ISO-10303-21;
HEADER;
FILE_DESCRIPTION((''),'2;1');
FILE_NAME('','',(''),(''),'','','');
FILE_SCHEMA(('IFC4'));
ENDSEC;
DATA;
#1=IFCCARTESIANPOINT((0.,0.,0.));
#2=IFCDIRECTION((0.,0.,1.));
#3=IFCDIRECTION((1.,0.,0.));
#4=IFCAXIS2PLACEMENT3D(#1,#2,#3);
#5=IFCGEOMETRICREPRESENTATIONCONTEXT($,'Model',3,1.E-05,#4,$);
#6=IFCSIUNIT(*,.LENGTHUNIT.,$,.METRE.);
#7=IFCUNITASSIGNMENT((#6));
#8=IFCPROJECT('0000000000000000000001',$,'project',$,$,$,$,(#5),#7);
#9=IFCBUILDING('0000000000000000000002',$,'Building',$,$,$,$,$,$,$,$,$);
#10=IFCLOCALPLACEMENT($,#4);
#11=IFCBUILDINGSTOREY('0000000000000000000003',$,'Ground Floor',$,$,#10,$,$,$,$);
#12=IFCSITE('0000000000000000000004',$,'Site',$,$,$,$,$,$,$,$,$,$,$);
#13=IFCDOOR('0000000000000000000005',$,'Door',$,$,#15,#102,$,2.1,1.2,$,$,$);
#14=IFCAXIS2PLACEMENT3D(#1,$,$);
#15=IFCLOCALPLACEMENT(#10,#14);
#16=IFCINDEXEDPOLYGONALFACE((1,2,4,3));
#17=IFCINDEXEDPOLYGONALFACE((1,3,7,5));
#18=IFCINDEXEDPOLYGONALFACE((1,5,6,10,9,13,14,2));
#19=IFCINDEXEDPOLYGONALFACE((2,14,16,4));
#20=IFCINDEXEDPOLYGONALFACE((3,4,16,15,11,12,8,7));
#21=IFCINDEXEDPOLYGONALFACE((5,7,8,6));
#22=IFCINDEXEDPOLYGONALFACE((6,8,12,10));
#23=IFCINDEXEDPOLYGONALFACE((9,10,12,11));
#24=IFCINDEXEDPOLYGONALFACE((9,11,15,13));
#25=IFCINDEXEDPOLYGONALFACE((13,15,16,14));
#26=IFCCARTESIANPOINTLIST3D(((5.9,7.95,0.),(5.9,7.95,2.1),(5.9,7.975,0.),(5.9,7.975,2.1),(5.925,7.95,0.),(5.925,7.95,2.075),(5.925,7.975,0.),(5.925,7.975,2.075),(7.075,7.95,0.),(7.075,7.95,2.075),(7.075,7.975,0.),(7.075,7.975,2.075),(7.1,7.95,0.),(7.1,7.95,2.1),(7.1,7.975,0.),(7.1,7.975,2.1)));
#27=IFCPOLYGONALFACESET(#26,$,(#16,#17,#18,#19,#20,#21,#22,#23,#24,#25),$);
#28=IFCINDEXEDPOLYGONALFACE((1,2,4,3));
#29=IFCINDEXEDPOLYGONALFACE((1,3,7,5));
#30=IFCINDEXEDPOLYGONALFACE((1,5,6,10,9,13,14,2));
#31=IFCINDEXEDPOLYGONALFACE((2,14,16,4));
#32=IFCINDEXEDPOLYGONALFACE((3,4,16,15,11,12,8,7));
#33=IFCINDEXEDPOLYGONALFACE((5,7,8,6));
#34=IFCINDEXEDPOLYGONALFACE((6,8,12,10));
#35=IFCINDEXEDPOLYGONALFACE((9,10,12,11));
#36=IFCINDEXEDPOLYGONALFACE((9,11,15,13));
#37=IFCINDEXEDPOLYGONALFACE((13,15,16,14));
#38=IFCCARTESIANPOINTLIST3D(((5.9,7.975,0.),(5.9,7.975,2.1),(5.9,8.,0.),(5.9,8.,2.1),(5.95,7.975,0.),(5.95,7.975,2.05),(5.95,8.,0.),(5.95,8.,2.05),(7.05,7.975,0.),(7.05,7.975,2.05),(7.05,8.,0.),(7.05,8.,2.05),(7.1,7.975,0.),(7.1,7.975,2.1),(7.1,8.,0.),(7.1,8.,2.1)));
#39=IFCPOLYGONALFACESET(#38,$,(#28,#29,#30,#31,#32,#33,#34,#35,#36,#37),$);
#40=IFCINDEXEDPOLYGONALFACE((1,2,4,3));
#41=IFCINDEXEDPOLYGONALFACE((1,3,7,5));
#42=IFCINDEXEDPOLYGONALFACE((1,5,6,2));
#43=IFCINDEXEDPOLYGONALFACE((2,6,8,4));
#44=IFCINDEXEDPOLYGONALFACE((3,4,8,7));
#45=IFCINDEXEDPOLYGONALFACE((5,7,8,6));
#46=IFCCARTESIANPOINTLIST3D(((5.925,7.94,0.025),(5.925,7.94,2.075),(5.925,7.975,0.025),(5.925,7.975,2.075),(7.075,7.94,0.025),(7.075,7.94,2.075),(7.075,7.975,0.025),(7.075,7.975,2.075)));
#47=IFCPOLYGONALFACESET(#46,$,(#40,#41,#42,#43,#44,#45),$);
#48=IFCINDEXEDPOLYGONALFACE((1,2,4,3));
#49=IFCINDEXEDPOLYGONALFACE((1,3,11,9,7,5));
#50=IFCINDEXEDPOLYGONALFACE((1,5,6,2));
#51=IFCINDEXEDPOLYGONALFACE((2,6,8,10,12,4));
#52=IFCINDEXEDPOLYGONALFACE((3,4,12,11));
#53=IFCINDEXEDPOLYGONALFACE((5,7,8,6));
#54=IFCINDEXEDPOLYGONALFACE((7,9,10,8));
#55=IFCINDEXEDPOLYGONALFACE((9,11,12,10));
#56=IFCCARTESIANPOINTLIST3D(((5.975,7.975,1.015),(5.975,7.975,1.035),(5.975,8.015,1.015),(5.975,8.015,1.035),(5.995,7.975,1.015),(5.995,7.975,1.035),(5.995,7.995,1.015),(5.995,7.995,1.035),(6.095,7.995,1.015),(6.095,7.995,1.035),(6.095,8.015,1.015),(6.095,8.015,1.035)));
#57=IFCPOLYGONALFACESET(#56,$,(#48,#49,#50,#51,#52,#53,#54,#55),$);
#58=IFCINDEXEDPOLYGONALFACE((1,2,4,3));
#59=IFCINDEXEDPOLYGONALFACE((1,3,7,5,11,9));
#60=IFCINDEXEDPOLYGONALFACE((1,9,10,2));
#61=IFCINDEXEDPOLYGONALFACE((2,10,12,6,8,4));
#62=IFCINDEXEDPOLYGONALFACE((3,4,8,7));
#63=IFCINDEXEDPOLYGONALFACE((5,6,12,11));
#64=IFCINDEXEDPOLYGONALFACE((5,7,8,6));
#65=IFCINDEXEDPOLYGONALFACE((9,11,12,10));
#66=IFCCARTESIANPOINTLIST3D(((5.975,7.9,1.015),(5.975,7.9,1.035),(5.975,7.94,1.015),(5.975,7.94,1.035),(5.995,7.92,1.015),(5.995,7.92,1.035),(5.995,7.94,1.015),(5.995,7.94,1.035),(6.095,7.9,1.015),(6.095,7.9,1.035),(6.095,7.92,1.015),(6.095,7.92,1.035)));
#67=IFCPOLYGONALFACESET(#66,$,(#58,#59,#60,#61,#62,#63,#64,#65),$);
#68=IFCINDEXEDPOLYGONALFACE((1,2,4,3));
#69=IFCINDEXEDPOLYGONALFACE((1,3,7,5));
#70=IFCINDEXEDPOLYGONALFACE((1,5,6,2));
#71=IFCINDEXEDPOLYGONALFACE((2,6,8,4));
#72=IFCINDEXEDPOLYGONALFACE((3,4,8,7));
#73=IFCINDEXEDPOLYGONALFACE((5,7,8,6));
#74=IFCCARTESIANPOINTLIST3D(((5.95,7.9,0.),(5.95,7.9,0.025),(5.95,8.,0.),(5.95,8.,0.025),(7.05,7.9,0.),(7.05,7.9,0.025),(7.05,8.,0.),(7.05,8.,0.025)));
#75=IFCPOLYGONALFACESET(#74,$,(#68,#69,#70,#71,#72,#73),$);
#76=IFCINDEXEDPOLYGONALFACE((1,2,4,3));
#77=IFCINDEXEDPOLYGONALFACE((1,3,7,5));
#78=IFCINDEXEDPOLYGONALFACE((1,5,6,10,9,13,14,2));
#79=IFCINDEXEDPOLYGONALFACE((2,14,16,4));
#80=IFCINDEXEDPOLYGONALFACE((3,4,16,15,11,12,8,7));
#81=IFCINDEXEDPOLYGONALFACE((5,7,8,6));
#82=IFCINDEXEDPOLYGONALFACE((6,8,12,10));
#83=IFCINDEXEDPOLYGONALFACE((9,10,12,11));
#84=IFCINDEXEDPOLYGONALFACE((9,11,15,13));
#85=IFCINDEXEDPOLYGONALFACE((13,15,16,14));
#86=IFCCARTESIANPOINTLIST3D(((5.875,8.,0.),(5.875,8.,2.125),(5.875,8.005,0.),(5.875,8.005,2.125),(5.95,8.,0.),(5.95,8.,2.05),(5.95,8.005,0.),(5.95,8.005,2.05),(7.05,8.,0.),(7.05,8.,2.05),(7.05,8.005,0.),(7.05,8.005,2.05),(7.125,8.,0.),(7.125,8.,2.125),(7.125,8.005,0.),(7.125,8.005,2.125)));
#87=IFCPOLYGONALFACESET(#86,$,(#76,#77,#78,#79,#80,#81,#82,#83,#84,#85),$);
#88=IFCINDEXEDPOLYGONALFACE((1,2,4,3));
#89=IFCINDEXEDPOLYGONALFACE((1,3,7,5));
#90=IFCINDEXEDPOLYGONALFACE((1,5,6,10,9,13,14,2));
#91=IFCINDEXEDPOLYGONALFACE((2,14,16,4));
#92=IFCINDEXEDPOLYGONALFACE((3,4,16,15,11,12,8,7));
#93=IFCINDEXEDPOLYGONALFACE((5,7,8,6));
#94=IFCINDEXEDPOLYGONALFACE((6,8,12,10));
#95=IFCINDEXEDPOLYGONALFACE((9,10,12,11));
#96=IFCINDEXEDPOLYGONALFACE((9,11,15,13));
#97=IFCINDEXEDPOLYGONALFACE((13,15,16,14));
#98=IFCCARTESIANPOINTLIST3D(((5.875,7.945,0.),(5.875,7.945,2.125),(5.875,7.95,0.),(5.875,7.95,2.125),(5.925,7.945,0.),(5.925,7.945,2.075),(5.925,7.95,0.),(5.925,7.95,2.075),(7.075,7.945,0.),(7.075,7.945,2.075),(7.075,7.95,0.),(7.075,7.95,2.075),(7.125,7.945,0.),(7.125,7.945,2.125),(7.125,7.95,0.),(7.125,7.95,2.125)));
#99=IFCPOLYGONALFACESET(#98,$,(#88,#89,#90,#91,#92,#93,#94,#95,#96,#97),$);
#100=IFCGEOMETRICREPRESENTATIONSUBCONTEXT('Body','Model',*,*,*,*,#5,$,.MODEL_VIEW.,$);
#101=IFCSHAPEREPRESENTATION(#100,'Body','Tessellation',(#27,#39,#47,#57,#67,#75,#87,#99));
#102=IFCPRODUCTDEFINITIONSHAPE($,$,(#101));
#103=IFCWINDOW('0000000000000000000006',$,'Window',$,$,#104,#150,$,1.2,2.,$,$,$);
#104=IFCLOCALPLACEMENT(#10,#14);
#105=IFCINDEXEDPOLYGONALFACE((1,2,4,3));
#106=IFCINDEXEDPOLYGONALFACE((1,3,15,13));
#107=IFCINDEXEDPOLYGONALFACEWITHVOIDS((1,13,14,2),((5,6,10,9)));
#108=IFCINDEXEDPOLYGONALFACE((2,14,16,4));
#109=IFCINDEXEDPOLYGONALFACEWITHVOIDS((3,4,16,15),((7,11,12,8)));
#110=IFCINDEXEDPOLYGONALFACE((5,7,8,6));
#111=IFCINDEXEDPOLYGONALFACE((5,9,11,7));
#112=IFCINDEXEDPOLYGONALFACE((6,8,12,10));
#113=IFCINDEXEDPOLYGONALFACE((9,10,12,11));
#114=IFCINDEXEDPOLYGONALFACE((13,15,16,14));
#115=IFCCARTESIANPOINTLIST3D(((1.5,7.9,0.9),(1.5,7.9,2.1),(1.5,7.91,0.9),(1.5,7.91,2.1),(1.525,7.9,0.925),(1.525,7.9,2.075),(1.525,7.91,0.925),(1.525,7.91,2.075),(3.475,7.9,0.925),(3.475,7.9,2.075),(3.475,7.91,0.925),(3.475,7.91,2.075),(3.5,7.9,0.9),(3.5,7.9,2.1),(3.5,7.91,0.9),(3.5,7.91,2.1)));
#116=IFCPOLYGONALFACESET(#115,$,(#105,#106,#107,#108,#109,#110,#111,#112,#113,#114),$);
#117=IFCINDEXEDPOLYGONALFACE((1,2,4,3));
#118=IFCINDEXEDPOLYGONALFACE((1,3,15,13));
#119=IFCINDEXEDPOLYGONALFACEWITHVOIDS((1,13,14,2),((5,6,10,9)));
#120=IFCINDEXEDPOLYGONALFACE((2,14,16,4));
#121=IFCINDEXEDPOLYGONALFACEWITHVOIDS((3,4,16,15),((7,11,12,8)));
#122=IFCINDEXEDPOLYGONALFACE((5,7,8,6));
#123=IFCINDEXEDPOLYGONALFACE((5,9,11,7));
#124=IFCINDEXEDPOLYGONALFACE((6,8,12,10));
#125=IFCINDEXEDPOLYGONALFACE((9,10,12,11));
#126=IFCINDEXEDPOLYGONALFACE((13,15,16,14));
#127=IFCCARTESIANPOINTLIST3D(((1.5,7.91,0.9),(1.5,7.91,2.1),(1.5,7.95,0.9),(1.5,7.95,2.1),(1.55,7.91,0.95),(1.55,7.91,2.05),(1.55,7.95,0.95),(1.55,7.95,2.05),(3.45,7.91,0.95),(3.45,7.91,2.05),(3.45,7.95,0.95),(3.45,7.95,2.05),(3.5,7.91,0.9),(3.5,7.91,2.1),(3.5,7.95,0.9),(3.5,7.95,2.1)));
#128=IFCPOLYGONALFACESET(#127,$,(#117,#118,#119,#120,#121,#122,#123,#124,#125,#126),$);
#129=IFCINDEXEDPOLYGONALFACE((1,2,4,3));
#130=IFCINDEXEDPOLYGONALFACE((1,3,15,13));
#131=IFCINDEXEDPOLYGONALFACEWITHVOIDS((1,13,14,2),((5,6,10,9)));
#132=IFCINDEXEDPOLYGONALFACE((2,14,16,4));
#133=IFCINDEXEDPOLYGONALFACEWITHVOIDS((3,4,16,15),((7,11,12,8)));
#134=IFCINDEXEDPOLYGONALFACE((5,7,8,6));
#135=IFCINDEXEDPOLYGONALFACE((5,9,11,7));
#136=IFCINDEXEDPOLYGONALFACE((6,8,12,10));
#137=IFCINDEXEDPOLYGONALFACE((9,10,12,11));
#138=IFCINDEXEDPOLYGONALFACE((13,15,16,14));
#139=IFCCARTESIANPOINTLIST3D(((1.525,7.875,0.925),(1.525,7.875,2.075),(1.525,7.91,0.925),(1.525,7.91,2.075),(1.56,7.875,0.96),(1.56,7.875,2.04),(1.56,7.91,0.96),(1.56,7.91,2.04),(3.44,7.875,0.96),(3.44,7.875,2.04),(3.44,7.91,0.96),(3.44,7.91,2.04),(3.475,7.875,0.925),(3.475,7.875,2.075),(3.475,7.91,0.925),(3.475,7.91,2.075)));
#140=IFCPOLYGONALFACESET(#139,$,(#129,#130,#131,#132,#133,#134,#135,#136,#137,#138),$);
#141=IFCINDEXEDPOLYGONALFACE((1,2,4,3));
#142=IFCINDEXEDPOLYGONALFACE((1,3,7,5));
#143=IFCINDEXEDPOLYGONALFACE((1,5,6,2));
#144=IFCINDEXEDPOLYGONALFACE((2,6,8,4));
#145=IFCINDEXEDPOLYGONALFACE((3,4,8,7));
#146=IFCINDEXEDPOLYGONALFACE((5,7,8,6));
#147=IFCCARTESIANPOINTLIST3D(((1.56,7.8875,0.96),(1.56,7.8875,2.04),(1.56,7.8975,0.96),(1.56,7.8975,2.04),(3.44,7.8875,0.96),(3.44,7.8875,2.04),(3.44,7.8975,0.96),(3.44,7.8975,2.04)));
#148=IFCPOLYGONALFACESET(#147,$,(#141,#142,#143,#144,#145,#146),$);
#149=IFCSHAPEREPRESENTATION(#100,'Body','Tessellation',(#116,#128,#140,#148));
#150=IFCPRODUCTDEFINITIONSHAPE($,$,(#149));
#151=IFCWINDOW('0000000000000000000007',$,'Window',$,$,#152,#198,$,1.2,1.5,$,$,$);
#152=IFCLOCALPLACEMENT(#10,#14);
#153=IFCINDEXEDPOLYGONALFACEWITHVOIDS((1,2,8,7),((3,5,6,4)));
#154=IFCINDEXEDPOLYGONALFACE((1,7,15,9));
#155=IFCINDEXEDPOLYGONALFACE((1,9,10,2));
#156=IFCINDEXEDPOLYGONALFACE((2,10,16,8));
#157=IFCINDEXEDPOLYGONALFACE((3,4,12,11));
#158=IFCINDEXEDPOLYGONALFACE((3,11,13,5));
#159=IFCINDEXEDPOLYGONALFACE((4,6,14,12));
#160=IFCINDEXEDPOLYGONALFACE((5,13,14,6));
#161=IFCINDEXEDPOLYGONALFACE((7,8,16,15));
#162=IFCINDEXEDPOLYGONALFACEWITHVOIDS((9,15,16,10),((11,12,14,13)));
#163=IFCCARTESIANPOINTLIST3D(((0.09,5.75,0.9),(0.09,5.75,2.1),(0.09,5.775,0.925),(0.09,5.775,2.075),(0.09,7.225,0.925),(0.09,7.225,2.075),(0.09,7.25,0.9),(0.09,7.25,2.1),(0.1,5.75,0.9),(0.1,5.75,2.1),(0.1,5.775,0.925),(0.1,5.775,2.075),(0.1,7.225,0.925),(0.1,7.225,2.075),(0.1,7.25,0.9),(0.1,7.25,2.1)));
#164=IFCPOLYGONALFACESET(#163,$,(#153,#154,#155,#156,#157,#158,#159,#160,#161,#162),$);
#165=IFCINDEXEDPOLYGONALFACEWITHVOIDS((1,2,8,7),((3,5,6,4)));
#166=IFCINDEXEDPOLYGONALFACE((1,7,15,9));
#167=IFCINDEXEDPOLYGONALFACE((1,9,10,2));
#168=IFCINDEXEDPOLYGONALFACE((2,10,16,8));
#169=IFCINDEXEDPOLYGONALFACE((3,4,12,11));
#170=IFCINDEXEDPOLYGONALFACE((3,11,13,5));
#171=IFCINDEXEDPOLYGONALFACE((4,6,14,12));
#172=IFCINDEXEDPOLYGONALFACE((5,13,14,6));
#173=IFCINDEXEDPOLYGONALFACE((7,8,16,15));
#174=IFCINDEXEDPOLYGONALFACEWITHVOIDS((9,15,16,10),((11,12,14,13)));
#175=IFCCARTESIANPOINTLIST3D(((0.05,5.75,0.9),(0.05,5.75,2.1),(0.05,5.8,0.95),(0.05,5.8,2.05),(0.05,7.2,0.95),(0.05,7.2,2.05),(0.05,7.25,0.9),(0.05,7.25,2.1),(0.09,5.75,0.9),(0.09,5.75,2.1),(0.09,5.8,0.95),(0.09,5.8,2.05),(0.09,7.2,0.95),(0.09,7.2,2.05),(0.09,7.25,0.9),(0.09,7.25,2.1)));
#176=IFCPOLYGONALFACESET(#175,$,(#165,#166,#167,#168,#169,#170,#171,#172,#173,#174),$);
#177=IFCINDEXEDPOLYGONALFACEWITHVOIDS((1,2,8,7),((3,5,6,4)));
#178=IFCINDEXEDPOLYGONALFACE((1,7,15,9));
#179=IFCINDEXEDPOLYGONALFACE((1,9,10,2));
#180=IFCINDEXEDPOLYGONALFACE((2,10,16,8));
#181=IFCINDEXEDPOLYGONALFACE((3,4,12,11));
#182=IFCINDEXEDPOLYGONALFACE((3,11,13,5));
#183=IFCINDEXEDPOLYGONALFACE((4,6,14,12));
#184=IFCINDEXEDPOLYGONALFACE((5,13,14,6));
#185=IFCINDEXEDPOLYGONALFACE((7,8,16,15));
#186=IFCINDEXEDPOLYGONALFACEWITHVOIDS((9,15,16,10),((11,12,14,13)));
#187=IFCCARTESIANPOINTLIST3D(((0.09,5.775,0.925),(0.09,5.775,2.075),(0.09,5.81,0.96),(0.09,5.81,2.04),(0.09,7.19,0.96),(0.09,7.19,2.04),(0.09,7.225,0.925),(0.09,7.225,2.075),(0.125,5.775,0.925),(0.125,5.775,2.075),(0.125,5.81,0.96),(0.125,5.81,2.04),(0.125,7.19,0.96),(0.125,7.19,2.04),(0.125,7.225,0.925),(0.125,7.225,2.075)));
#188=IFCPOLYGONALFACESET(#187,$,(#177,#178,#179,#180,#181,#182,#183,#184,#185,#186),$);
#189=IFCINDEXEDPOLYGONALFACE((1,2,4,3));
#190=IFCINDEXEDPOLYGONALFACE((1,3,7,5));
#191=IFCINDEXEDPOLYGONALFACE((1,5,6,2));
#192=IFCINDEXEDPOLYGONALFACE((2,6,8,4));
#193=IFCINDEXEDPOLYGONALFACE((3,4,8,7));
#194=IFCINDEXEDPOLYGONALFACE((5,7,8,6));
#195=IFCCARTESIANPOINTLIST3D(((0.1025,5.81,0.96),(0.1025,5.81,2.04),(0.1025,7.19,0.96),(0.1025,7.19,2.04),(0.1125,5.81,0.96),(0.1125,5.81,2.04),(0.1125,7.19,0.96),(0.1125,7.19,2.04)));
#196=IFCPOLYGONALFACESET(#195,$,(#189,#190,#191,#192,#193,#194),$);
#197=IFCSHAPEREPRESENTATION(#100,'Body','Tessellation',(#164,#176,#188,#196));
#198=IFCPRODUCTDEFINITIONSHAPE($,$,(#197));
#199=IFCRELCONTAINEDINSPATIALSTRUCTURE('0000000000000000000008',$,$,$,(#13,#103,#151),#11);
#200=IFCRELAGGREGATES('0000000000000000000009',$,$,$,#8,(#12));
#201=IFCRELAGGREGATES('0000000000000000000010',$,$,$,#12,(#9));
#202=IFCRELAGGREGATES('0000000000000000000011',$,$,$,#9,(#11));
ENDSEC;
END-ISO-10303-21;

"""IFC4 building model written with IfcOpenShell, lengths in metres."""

from ifc_helpers import new_model, si_unit, frame, origin_with_axes, place, context, subcontext, project, spatial, line, indexed_curve, outline, extrude, element, save


model = new_model("IFC4")

# Units and contexts
model_context = context("Model", 3, precision=1e-05, world=origin_with_axes())
body_context = subcontext(model_context, "Body", "Model", "MODEL_VIEW")
ifc_project = project(units=[si_unit("LENGTHUNIT", "METRE")], contexts=[model_context])

# Site, building, storey
site = spatial("IfcSite", under=ifc_project, Name="Site")
building = spatial("IfcBuilding", under=site, Name="Building")
storey_placement = place(None, origin_with_axes())
storey = spatial("IfcBuildingStorey", under=building, at=storey_placement, Name="Ground Floor")

# Door
door_1_placement = place(storey_placement, frame((7.1, 8.0, 0.0), z_axis=(0.0, 0.0, 1.0), x_axis=(-1.0, 0.0, 0.0)))
element("IfcDoor", 1, at=door_1_placement, inside=storey, Name="Door", OverallHeight=2.1, OverallWidth=1.2, context=body_context, shape_type="SweptSolid", body=[
    extrude(outline(indexed_curve([(0.0, 0.0), (0.0, 2.1), (1.2, 2.1), (1.2, 0.0), (1.175, 0.0), (1.175, 2.075), (0.025, 2.075), (0.025, 0.0)], segments=[line(1, 2, 3, 4, 5, 6, 7, 8, 1)])), frame((0.0, 0.025, 0.0), z_axis=(0.0, -1.0, 0.0), x_axis=(1.0, 0.0, 0.0)), (0.0, 0.0, -1.0), 0.025),
    extrude(outline(indexed_curve([(0.0, 0.0), (0.0, 2.1), (1.2, 2.1), (1.2, 0.0), (1.15, 0.0), (1.15, 2.05), (0.05, 2.05), (0.05, 0.0)], segments=[line(1, 2, 3, 4, 5, 6, 7, 8, 1)])), frame((0.0, 0.0, 0.0), z_axis=(0.0, -1.0, 0.0), x_axis=(1.0, 0.0, 0.0)), (0.0, 0.0, -1.0), 0.025),
    extrude(outline(indexed_curve([(0.0, 0.0), (1.15, 0.0), (1.15, 0.035), (0.0, 0.035)], segments=[line(1, 2, 3, 4, 1)])), frame((0.025, 0.025, 0.025), z_axis=(0.0, 0.0, 1.0), x_axis=(1.0, 0.0, 0.0)), (0.0, 0.0, 1.0), 2.05),
    extrude(outline(indexed_curve([(0.0, 0.0), (0.0, -0.04), (-0.12, -0.04), (-0.12, -0.02), (-0.02, -0.02), (-0.02, 0.0)], segments=[line(1, 2, 3, 4, 5, 6, 1)])), frame((1.125, 0.025, 1.015), z_axis=(0.0, 0.0, 1.0), x_axis=(1.0, 0.0, 0.0)), (0.0, 0.0, 1.0), 0.02),
    extrude(outline(indexed_curve([(0.0, 0.0), (0.0, 0.04), (-0.12, 0.04), (-0.12, 0.02), (-0.02, 0.02), (-0.02, 0.0)], segments=[line(1, 2, 3, 4, 5, 6, 1)])), frame((1.125, 0.06, 1.015), z_axis=(0.0, 0.0, 1.0), x_axis=(1.0, 0.0, 0.0)), (0.0, 0.0, 1.0), 0.02),
    extrude(outline(indexed_curve([(0.0, 0.0), (1.1, 0.0), (1.1, 0.1), (0.0, 0.1)], segments=[line(1, 2, 3, 4, 1)])), frame((0.05, 0.0, 0.0), z_axis=(0.0, 0.0, 1.0), x_axis=(1.0, 0.0, 0.0)), (0.0, 0.0, 1.0), 0.025),
    extrude(outline(indexed_curve([(0.0, 0.0), (0.0, 2.125), (1.25, 2.125), (1.25, 0.0), (1.175, 0.0), (1.175, 2.05), (0.075, 2.05), (0.075, 0.0)], segments=[line(1, 2, 3, 4, 5, 6, 7, 8, 1)])), frame((-0.025, -0.005, 0.0), z_axis=(0.0, -1.0, 0.0), x_axis=(1.0, 0.0, 0.0)), (0.0, 0.0, -1.0), 0.005),
    extrude(outline(indexed_curve([(0.0, 0.0), (0.0, 2.125), (1.25, 2.125), (1.25, 0.0), (1.2, 0.0), (1.2, 2.075), (0.05, 2.075), (0.05, 0.0)], segments=[line(1, 2, 3, 4, 5, 6, 7, 8, 1)])), frame((-0.025, 0.05, 0.0), z_axis=(0.0, -1.0, 0.0), x_axis=(1.0, 0.0, 0.0)), (0.0, 0.0, -1.0), 0.005),
])

# Windows
window_1_placement = place(storey_placement, frame((3.5, 8.0, 0.9), z_axis=(0.0, 0.0, 1.0), x_axis=(-1.0, 0.0, 0.0)))
element("IfcWindow", 2, at=window_1_placement, inside=storey, Name="Window", OverallHeight=1.2, OverallWidth=2.0, context=body_context, shape_type="SweptSolid", body=[
    extrude(outline(indexed_curve([(0.0, 0.0), (2.0, 0.0), (2.0, 1.2), (0.0, 1.2)], segments=[line(1, 2, 3, 4, 1)]), holes=[indexed_curve([(0.025, 0.025), (1.975, 0.025), (1.975, 1.175), (0.025, 1.175)], segments=[line(1, 2, 3, 4, 1)])]), frame((0.0, 0.09, 0.0), z_axis=(0.0, -1.0, 0.0), x_axis=(1.0, 0.0, 0.0)), (0.0, 0.0, -1.0), 0.01),
    extrude(outline(indexed_curve([(0.0, 0.0), (2.0, 0.0), (2.0, 1.2), (0.0, 1.2)], segments=[line(1, 2, 3, 4, 1)]), holes=[indexed_curve([(0.05, 0.05), (1.95, 0.05), (1.95, 1.15), (0.05, 1.15)], segments=[line(1, 2, 3, 4, 1)])]), frame((0.0, 0.05, 0.0), z_axis=(0.0, -1.0, 0.0), x_axis=(1.0, 0.0, 0.0)), (0.0, 0.0, -1.0), 0.04),
    extrude(outline(indexed_curve([(0.0, 0.0), (1.95, 0.0), (1.95, 1.15), (0.0, 1.15)], segments=[line(1, 2, 3, 4, 1)]), holes=[indexed_curve([(0.035, 0.035), (1.915, 0.035), (1.915, 1.115), (0.035, 1.115)], segments=[line(1, 2, 3, 4, 1)])]), frame((0.025, 0.09, 0.025), z_axis=(0.0, -1.0, 0.0), x_axis=(1.0, 0.0, 0.0)), (0.0, 0.0, -1.0), 0.035),
    extrude(outline(indexed_curve([(0.035, 0.035), (1.915, 0.035), (1.915, 1.115), (0.035, 1.115)], segments=[line(1, 2, 3, 4, 1)])), frame((0.025, 0.1025, 0.025), z_axis=(0.0, -1.0, 0.0), x_axis=(1.0, 0.0, 0.0)), (0.0, 0.0, -1.0), 0.01),
])
for number, where, z_axis, x_axis, name in (
    (3, (0.0, 7.25, 0.9), (0.0, 0.0, 1.0), (0.0, -1.0, 0.0), "Window"),
):
    element("IfcWindow", number, at=place(storey_placement, frame(where, z_axis=z_axis, x_axis=x_axis)), inside=storey, Name=name, OverallHeight=1.2, OverallWidth=1.5, context=body_context, shape_type="SweptSolid", body=[
        extrude(outline(indexed_curve([(0.0, 0.0), (1.5, 0.0), (1.5, 1.2), (0.0, 1.2)], segments=[line(1, 2, 3, 4, 1)]), holes=[indexed_curve([(0.025, 0.025), (1.475, 0.025), (1.475, 1.175), (0.025, 1.175)], segments=[line(1, 2, 3, 4, 1)])]), frame((0.0, 0.09, 0.0), z_axis=(0.0, -1.0, 0.0), x_axis=(1.0, 0.0, 0.0)), (0.0, 0.0, -1.0), 0.01),
        extrude(outline(indexed_curve([(0.0, 0.0), (1.5, 0.0), (1.5, 1.2), (0.0, 1.2)], segments=[line(1, 2, 3, 4, 1)]), holes=[indexed_curve([(0.05, 0.05), (1.45, 0.05), (1.45, 1.15), (0.05, 1.15)], segments=[line(1, 2, 3, 4, 1)])]), frame((0.0, 0.05, 0.0), z_axis=(0.0, -1.0, 0.0), x_axis=(1.0, 0.0, 0.0)), (0.0, 0.0, -1.0), 0.04),
        extrude(outline(indexed_curve([(0.0, 0.0), (1.45, 0.0), (1.45, 1.15), (0.0, 1.15)], segments=[line(1, 2, 3, 4, 1)]), holes=[indexed_curve([(0.035, 0.035), (1.415, 0.035), (1.415, 1.115), (0.035, 1.115)], segments=[line(1, 2, 3, 4, 1)])]), frame((0.025, 0.09, 0.025), z_axis=(0.0, -1.0, 0.0), x_axis=(1.0, 0.0, 0.0)), (0.0, 0.0, -1.0), 0.035),
        extrude(outline(indexed_curve([(0.035, 0.035), (1.415, 0.035), (1.415, 1.115), (0.035, 1.115)], segments=[line(1, 2, 3, 4, 1)])), frame((0.025, 0.1025, 0.025), z_axis=(0.0, -1.0, 0.0), x_axis=(1.0, 0.0, 0.0)), (0.0, 0.0, -1.0), 0.01),
    ])

save(model, "model.ifc")
